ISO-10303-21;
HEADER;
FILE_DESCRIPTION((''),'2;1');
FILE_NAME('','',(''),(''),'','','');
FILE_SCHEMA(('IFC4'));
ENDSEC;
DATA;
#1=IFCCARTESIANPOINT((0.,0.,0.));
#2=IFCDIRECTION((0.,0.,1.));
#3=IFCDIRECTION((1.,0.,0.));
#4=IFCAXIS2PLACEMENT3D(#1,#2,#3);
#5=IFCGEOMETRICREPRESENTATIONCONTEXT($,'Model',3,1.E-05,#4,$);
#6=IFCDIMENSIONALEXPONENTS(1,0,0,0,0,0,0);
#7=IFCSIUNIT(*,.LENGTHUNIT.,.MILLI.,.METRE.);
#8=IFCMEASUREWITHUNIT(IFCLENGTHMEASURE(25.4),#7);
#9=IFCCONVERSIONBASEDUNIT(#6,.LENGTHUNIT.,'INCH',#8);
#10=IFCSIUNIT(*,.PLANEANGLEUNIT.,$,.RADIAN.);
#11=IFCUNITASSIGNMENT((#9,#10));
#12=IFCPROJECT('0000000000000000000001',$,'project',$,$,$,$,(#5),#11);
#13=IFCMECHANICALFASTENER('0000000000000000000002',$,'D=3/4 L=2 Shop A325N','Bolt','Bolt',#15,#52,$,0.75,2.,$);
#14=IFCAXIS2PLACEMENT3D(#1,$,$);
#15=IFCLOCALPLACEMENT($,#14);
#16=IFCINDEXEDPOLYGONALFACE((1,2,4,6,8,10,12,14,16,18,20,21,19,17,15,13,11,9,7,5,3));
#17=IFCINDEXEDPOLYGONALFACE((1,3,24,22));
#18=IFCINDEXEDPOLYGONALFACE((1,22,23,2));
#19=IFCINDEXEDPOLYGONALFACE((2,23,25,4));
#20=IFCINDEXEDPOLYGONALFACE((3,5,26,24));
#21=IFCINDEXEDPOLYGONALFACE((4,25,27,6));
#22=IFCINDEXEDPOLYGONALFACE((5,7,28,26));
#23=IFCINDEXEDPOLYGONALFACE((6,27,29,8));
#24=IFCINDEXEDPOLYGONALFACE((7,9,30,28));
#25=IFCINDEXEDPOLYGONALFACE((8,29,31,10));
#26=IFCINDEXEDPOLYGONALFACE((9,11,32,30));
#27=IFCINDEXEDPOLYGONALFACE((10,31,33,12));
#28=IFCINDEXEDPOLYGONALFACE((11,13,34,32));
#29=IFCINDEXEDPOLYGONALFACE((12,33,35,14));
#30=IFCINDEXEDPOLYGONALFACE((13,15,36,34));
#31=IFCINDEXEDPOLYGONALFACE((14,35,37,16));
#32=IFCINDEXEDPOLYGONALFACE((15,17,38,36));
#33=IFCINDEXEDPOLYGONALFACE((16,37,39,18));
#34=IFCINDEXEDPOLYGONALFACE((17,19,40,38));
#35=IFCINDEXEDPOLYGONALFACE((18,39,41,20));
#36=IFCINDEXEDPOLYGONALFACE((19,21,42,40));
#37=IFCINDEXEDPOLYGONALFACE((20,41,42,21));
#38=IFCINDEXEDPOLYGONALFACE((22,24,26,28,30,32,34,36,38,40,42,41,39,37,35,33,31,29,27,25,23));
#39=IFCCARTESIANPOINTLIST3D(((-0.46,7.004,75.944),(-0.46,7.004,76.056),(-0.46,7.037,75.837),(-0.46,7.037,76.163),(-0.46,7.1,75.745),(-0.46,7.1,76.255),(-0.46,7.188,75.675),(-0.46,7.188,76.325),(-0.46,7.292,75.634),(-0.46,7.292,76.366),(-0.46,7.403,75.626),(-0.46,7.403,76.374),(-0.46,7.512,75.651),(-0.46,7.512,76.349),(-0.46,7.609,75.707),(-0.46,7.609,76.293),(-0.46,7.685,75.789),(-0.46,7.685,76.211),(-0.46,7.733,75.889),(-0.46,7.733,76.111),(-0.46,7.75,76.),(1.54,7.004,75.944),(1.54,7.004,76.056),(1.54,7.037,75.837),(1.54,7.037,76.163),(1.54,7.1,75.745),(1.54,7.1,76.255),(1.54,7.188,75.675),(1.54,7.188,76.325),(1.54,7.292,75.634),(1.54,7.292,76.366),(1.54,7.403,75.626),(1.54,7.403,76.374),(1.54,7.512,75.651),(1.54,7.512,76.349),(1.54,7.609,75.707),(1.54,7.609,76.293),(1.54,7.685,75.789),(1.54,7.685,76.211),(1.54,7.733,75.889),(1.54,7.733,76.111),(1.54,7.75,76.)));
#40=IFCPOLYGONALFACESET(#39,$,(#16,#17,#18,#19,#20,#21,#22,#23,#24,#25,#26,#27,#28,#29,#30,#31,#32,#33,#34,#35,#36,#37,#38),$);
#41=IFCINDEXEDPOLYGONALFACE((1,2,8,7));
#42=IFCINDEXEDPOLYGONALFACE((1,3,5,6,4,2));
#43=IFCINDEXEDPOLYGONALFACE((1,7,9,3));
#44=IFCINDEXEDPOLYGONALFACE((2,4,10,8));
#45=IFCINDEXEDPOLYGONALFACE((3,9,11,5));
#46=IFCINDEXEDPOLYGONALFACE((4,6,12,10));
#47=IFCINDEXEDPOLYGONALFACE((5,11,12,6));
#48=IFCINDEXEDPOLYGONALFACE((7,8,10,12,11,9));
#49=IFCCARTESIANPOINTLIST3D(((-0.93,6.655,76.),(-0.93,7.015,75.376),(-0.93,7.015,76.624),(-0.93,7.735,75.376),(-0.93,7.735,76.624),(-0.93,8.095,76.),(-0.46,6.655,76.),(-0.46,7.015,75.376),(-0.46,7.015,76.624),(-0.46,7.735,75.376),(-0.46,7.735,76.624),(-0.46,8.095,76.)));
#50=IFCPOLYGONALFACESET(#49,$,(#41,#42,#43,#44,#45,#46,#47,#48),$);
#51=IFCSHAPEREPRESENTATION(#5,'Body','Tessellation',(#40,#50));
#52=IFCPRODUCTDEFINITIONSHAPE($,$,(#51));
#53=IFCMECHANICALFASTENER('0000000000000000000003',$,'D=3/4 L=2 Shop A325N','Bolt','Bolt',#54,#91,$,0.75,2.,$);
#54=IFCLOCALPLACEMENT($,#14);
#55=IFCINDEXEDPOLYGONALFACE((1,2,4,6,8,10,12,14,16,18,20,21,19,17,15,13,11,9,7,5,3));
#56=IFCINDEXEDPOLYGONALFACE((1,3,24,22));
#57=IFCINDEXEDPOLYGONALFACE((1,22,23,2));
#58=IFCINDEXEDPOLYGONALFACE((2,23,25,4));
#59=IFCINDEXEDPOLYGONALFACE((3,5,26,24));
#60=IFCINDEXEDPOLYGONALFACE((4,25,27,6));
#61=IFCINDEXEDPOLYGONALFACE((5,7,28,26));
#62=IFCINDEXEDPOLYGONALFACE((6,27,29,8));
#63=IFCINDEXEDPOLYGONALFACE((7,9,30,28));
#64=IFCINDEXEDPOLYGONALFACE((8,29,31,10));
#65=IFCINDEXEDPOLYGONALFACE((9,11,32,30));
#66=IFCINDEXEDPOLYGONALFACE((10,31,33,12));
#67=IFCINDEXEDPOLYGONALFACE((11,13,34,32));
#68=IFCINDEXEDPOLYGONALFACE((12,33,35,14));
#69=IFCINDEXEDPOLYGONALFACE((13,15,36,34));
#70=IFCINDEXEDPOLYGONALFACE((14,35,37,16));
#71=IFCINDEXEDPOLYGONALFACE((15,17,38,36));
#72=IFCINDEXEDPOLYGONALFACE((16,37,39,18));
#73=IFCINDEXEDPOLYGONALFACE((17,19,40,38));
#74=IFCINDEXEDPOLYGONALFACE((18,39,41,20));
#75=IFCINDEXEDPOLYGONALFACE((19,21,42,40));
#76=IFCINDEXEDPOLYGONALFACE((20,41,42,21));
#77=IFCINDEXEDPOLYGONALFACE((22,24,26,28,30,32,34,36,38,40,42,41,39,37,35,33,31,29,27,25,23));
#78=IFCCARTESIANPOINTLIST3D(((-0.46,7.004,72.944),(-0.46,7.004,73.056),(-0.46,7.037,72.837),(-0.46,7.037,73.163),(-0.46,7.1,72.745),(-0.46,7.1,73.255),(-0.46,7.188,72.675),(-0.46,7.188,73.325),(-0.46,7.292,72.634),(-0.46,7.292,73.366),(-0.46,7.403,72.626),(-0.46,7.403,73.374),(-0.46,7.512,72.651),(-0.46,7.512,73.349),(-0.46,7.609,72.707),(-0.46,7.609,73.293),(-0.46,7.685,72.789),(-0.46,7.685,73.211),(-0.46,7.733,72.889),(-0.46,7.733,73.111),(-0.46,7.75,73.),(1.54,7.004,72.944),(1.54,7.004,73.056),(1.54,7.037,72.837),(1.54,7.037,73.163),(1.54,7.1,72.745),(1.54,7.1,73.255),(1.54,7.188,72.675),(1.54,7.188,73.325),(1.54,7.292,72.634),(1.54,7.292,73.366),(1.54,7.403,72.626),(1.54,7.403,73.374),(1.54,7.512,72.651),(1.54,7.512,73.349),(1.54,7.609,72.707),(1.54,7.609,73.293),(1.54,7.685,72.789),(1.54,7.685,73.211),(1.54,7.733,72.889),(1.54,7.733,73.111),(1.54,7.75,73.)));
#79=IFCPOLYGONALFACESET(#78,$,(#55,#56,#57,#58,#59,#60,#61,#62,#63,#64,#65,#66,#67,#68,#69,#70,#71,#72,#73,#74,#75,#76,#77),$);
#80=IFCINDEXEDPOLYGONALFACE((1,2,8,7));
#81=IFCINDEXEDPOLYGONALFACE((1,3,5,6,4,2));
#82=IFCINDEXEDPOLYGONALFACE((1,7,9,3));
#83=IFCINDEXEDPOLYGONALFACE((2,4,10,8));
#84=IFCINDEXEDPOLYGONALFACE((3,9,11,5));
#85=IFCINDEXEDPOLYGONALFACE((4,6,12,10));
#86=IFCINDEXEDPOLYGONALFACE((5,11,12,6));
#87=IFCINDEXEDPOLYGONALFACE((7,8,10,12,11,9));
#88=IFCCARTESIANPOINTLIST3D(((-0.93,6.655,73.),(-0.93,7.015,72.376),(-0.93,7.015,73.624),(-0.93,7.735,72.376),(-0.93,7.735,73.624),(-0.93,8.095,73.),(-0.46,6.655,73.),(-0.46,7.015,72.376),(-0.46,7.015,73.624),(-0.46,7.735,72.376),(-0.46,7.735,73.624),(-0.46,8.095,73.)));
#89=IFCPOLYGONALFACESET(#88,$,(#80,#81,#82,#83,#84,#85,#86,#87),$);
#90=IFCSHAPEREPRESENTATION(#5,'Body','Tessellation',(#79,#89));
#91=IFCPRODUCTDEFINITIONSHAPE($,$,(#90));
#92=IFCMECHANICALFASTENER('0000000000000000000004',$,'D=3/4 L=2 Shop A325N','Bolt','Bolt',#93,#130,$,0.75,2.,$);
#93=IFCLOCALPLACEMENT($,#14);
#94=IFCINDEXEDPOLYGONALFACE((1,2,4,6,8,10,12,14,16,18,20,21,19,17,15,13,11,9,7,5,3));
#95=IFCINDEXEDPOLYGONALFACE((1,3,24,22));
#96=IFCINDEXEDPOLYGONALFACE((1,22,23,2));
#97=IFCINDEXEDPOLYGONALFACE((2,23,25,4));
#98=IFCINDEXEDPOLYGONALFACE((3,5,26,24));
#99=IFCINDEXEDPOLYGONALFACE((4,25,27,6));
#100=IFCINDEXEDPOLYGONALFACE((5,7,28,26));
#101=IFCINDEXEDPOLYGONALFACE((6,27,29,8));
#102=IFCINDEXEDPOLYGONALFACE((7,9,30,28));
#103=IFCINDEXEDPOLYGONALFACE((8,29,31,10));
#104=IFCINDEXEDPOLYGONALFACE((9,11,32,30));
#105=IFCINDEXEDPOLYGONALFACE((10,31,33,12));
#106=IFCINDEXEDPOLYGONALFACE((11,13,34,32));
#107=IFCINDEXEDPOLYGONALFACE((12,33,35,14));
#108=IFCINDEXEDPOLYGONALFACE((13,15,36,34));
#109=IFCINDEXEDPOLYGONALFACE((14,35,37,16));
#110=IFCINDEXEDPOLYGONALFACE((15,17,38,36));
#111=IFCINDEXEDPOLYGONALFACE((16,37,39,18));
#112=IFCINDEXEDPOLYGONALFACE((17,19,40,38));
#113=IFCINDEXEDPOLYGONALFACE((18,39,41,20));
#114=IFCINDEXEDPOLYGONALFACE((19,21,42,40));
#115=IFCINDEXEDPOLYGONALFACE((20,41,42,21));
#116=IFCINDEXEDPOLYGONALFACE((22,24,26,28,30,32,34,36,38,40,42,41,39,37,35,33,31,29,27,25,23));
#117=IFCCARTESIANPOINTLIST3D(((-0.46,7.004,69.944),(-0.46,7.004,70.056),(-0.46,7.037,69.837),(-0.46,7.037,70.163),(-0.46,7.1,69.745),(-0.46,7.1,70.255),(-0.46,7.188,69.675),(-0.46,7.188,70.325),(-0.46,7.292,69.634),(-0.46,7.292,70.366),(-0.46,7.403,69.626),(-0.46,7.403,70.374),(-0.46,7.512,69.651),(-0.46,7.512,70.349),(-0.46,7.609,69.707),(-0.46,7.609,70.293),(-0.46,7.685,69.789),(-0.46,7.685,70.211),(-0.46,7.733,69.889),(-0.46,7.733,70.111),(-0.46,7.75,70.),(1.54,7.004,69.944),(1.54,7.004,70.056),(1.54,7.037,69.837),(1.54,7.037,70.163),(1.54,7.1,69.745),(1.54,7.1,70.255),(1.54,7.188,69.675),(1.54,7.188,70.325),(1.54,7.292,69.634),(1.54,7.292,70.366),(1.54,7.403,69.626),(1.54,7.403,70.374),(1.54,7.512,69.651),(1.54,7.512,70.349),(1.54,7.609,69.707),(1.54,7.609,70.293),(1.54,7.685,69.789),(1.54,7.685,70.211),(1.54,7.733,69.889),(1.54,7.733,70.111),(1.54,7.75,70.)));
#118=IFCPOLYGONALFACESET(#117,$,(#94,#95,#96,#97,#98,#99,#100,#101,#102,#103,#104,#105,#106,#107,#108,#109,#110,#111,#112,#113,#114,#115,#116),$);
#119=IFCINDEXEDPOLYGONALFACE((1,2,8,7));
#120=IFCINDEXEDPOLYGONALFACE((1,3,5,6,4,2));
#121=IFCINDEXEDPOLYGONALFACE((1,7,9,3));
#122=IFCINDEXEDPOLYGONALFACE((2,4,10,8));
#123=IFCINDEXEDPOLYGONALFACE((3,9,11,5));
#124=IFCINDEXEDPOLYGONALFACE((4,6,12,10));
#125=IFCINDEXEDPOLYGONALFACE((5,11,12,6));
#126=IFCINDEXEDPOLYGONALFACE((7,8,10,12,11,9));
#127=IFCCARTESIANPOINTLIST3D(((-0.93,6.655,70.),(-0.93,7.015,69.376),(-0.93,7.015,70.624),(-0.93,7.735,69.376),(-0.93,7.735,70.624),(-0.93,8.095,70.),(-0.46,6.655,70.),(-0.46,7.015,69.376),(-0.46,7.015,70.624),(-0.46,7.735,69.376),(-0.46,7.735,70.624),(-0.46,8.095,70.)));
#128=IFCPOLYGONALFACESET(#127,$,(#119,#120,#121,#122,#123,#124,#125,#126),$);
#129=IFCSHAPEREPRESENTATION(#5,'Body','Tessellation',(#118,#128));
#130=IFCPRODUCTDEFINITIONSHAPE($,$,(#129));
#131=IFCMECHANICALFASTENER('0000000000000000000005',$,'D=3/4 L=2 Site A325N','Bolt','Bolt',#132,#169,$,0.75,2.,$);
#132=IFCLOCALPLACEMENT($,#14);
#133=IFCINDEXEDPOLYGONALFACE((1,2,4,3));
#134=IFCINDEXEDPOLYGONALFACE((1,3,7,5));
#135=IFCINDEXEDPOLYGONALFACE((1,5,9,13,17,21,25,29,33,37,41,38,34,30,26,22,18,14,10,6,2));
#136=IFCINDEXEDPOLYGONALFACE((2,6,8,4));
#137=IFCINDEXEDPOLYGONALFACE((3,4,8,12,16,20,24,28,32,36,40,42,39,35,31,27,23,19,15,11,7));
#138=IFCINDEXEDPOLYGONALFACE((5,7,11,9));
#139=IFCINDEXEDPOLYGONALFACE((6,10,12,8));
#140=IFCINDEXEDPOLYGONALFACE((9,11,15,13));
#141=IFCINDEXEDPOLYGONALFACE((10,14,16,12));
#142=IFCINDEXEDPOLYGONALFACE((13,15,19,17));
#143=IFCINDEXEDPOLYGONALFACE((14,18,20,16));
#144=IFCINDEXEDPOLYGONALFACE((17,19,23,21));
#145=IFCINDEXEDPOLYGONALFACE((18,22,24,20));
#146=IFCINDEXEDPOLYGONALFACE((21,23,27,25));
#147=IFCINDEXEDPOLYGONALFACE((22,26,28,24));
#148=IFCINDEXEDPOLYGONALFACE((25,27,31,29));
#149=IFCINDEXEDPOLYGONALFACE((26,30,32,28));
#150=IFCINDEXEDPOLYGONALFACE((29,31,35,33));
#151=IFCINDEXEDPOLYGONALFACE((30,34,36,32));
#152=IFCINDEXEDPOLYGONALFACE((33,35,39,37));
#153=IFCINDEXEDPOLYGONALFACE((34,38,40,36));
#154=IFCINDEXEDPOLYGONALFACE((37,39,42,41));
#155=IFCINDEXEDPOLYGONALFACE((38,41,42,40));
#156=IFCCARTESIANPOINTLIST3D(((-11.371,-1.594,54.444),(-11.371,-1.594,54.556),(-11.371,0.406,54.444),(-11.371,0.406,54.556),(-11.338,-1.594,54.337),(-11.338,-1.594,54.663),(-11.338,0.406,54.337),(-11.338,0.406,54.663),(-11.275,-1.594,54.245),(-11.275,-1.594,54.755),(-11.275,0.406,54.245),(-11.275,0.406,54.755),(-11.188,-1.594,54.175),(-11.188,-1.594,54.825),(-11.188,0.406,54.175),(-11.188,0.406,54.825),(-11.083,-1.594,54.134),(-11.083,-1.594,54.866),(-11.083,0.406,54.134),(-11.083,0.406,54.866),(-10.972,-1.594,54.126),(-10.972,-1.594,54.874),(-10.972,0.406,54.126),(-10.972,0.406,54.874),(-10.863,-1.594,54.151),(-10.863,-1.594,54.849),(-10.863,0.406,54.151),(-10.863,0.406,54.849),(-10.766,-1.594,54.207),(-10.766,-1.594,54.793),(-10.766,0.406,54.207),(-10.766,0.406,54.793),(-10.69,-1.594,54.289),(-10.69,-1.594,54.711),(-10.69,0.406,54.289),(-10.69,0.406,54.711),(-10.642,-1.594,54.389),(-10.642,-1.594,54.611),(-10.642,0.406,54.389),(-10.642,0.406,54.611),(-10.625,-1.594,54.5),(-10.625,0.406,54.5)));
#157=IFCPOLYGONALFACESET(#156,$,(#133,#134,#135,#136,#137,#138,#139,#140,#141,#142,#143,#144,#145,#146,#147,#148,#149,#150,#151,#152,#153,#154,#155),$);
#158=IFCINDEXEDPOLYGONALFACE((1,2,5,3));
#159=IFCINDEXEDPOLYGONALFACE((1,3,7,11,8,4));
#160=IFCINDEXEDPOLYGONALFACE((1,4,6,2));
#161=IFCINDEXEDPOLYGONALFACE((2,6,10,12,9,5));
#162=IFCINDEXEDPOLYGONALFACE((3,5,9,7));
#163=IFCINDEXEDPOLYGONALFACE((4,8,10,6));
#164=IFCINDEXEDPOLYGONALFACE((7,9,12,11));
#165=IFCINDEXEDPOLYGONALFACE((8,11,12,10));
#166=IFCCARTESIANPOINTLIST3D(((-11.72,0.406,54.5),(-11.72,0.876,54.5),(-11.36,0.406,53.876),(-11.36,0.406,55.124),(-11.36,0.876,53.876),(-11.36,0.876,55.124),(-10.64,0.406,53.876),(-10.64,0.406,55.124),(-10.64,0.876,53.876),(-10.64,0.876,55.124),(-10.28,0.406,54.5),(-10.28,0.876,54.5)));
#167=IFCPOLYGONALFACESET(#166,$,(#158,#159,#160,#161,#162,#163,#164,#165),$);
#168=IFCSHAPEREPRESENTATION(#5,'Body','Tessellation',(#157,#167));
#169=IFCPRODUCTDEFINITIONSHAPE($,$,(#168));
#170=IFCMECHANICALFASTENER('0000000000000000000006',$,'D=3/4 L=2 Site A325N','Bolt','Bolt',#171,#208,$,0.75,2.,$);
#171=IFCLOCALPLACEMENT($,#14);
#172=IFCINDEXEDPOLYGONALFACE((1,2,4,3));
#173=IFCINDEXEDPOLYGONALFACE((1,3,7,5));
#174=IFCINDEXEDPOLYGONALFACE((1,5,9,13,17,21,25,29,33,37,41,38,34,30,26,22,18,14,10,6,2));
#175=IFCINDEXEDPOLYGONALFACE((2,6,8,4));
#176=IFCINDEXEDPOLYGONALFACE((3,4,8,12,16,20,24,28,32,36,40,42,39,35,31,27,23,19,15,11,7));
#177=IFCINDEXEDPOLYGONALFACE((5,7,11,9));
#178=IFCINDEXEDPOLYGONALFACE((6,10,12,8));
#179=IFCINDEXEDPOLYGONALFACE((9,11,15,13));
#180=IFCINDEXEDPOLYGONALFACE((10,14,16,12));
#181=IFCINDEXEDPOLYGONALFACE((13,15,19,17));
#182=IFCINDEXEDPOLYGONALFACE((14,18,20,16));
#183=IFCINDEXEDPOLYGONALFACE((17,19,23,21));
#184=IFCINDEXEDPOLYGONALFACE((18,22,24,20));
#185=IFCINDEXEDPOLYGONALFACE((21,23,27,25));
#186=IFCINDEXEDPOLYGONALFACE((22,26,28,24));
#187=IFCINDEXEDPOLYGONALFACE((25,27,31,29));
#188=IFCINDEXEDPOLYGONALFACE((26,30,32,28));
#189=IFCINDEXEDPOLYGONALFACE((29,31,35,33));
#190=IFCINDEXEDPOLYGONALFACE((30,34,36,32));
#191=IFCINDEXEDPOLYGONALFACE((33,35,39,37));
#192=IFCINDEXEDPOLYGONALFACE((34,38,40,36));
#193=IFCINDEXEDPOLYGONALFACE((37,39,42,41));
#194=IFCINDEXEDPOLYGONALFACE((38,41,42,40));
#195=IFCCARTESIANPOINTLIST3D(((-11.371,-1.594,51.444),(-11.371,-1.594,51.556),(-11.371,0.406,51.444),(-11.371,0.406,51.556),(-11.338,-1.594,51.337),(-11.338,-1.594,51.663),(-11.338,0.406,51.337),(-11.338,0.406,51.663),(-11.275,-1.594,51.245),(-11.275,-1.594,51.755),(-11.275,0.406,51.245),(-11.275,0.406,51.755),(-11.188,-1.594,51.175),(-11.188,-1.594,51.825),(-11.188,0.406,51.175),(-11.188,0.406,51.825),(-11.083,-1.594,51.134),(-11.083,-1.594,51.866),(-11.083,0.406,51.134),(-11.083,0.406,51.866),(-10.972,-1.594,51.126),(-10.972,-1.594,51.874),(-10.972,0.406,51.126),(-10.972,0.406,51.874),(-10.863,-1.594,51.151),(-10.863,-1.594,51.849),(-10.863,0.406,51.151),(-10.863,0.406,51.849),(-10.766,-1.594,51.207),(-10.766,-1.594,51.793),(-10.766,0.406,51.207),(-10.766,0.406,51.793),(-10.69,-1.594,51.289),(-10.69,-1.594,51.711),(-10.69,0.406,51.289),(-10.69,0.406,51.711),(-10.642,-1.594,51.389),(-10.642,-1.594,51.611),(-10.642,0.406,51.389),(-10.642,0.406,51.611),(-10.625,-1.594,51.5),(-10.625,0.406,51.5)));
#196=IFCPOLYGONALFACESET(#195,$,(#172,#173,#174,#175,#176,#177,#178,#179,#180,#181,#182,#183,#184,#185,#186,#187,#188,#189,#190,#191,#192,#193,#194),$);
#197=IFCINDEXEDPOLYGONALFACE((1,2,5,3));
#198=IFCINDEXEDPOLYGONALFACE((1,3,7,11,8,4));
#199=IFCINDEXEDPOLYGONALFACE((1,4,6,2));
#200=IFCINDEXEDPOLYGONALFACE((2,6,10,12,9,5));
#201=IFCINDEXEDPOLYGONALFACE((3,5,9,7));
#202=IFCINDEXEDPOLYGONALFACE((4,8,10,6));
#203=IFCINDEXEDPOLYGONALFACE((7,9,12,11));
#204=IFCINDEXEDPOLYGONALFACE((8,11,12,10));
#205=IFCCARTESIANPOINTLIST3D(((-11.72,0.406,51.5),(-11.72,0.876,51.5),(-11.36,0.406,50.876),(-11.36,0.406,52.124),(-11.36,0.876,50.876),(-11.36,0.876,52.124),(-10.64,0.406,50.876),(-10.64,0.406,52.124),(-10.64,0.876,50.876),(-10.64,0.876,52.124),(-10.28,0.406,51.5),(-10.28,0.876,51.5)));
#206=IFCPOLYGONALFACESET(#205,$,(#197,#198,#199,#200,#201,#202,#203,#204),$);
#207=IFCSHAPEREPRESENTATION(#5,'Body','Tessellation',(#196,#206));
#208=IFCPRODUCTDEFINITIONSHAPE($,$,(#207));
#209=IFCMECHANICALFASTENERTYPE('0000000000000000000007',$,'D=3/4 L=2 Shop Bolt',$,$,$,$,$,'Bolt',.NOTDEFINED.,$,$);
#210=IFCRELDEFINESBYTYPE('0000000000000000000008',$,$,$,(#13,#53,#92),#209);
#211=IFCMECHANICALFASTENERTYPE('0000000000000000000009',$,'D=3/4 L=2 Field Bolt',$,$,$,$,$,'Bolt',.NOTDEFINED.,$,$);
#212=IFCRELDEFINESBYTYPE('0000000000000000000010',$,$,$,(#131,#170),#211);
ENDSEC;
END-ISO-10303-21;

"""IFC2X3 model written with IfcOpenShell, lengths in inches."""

from ifc_helpers import new_model, entity, si_unit, converted_unit, frame, origin_with_axes, origin_2d_with_axis, place, context, project, polyline, circle, outline, extrude, source, transform, mapped, type_object, type_shapes, element, save


model = new_model("IFC2X3")

# Units and contexts
model_context = context("Model", 3, precision=1e-05, world=origin_with_axes())
ifc_project = project(units=[converted_unit("LENGTHUNIT", "INCH", entity("IfcLengthMeasure", 25.4), si_unit("LENGTHUNIT", "METRE", prefix="MILLI"), dimensions=[1, 0, 0, 0, 0, 0, 0]), si_unit("PLANEANGLEUNIT", "RADIAN")], contexts=[model_context])

# Mechanical fasteners
placement_1 = place(None, origin_with_axes())
placement_2 = place(placement_1, origin_with_axes())
mechanical_fastener_type_1 = type_object("IfcMechanicalFastenerType", Name="D=3/4 L=2 Shop Bolt", ElementType="Bolt")
shared_shape_1 = source(origin_with_axes(), model_context, "Body", "SweptSolid", [
    extrude(circle(Radius=0.375, at=origin_2d_with_axis()), frame((0.0, 0.0, 0.0), z_axis=(1.0, 0.0, 0.0), x_axis=(0.0, 1.0, 0.0)), (0.0, 0.0, 1.0), 2.0),
    extrude(outline(polyline([(-0.72, 0.0), (-0.36, 0.624), (0.36, 0.624), (0.72, 0.0), (0.36, -0.624), (-0.36, -0.624), (-0.72, 0.0)])), frame((0.0, 0.0, 0.0), z_axis=(1.0, 0.0, 0.0), x_axis=(0.0, 1.0, 0.0)), (0.0, 0.0, -1.0), 0.47),
])
type_shapes(mechanical_fastener_type_1, [shared_shape_1])
placement_3 = place(placement_2, frame((0.0, 0.0, 80.0), z_axis=(0.0, 0.0, 1.0), x_axis=(0.0, 1.0, 0.0)))
placement_4 = place(placement_3, frame((7.375, 0.46, -10.0), z_axis=(0.0, 0.0, 1.0), x_axis=(0.0, -1.0, 0.0)))
for number, where, z_axis, x_axis, name in (
    (1, (0.0, 0.0, 6.0), (0.0, 0.0, 1.0), (1.0, 0.0, 0.0), "D=3/4 L=2 Shop A325N"),
    (2, (0.0, 0.0, 3.0), (0.0, 0.0, 1.0), (1.0, 0.0, 0.0), "D=3/4 L=2 Shop A325N"),
    (3, (0.0, 0.0, 0.0), (0.0, 0.0, 1.0), (1.0, 0.0, 0.0), "D=3/4 L=2 Shop A325N"),
):
    element("IfcMechanicalFastener", number, at=place(placement_4, frame(where, z_axis=z_axis, x_axis=x_axis)), type_object=mechanical_fastener_type_1, Name=name, Description="Bolt", ObjectType="Bolt", NominalDiameter=0.75, NominalLength=2.0, context=model_context, shape_type="MappedRepresentation", body=[
        mapped(shared_shape_1, transform((0.0, 0.0, 0.0), scale=1.0)),
    ])
mechanical_fastener_type_2 = type_object("IfcMechanicalFastenerType", Name="D=3/4 L=2 Field Bolt", ElementType="Bolt")
shared_shape_2 = source(origin_with_axes(), model_context, "Body", "SweptSolid", [
    extrude(circle(Radius=0.375, at=origin_2d_with_axis()), frame((0.0, 0.0, 0.0), z_axis=(1.0, 0.0, 0.0), x_axis=(0.0, 1.0, 0.0)), (0.0, 0.0, 1.0), 2.0),
    extrude(outline(polyline([(-0.72, 0.0), (-0.36, 0.624), (0.36, 0.624), (0.72, 0.0), (0.36, -0.624), (-0.36, -0.624), (-0.72, 0.0)])), frame((0.0, 0.0, 0.0), z_axis=(1.0, 0.0, 0.0), x_axis=(0.0, 1.0, 0.0)), (0.0, 0.0, -1.0), 0.47),
])
type_shapes(mechanical_fastener_type_2, [shared_shape_2])
placement_5 = place(placement_2, frame((-9.25, 0.0, 57.0), z_axis=(0.0, 0.0, 1.0), x_axis=(-1.0, 0.0, 0.0)))
placement_6 = place(placement_5, frame((1.75, -0.406, -2.5), z_axis=(0.0, 0.0, 1.0), x_axis=(0.0, 1.0, 0.0)))
for number, where, z_axis, x_axis, name in (
    (4, (0.0, 0.0, 0.0), (0.0, 0.0, 1.0), (1.0, 0.0, 0.0), "D=3/4 L=2 Site A325N"),
    (5, (0.0, 0.0, -3.0), (0.0, 0.0, 1.0), (1.0, 0.0, 0.0), "D=3/4 L=2 Site A325N"),
):
    element("IfcMechanicalFastener", number, at=place(placement_6, frame(where, z_axis=z_axis, x_axis=x_axis)), type_object=mechanical_fastener_type_2, Name=name, Description="Bolt", ObjectType="Bolt", NominalDiameter=0.75, NominalLength=2.0, context=model_context, shape_type="MappedRepresentation", body=[
        mapped(shared_shape_2, transform((0.0, 0.0, 0.0), scale=1.0)),
    ])

save(model, "model.ifc")
